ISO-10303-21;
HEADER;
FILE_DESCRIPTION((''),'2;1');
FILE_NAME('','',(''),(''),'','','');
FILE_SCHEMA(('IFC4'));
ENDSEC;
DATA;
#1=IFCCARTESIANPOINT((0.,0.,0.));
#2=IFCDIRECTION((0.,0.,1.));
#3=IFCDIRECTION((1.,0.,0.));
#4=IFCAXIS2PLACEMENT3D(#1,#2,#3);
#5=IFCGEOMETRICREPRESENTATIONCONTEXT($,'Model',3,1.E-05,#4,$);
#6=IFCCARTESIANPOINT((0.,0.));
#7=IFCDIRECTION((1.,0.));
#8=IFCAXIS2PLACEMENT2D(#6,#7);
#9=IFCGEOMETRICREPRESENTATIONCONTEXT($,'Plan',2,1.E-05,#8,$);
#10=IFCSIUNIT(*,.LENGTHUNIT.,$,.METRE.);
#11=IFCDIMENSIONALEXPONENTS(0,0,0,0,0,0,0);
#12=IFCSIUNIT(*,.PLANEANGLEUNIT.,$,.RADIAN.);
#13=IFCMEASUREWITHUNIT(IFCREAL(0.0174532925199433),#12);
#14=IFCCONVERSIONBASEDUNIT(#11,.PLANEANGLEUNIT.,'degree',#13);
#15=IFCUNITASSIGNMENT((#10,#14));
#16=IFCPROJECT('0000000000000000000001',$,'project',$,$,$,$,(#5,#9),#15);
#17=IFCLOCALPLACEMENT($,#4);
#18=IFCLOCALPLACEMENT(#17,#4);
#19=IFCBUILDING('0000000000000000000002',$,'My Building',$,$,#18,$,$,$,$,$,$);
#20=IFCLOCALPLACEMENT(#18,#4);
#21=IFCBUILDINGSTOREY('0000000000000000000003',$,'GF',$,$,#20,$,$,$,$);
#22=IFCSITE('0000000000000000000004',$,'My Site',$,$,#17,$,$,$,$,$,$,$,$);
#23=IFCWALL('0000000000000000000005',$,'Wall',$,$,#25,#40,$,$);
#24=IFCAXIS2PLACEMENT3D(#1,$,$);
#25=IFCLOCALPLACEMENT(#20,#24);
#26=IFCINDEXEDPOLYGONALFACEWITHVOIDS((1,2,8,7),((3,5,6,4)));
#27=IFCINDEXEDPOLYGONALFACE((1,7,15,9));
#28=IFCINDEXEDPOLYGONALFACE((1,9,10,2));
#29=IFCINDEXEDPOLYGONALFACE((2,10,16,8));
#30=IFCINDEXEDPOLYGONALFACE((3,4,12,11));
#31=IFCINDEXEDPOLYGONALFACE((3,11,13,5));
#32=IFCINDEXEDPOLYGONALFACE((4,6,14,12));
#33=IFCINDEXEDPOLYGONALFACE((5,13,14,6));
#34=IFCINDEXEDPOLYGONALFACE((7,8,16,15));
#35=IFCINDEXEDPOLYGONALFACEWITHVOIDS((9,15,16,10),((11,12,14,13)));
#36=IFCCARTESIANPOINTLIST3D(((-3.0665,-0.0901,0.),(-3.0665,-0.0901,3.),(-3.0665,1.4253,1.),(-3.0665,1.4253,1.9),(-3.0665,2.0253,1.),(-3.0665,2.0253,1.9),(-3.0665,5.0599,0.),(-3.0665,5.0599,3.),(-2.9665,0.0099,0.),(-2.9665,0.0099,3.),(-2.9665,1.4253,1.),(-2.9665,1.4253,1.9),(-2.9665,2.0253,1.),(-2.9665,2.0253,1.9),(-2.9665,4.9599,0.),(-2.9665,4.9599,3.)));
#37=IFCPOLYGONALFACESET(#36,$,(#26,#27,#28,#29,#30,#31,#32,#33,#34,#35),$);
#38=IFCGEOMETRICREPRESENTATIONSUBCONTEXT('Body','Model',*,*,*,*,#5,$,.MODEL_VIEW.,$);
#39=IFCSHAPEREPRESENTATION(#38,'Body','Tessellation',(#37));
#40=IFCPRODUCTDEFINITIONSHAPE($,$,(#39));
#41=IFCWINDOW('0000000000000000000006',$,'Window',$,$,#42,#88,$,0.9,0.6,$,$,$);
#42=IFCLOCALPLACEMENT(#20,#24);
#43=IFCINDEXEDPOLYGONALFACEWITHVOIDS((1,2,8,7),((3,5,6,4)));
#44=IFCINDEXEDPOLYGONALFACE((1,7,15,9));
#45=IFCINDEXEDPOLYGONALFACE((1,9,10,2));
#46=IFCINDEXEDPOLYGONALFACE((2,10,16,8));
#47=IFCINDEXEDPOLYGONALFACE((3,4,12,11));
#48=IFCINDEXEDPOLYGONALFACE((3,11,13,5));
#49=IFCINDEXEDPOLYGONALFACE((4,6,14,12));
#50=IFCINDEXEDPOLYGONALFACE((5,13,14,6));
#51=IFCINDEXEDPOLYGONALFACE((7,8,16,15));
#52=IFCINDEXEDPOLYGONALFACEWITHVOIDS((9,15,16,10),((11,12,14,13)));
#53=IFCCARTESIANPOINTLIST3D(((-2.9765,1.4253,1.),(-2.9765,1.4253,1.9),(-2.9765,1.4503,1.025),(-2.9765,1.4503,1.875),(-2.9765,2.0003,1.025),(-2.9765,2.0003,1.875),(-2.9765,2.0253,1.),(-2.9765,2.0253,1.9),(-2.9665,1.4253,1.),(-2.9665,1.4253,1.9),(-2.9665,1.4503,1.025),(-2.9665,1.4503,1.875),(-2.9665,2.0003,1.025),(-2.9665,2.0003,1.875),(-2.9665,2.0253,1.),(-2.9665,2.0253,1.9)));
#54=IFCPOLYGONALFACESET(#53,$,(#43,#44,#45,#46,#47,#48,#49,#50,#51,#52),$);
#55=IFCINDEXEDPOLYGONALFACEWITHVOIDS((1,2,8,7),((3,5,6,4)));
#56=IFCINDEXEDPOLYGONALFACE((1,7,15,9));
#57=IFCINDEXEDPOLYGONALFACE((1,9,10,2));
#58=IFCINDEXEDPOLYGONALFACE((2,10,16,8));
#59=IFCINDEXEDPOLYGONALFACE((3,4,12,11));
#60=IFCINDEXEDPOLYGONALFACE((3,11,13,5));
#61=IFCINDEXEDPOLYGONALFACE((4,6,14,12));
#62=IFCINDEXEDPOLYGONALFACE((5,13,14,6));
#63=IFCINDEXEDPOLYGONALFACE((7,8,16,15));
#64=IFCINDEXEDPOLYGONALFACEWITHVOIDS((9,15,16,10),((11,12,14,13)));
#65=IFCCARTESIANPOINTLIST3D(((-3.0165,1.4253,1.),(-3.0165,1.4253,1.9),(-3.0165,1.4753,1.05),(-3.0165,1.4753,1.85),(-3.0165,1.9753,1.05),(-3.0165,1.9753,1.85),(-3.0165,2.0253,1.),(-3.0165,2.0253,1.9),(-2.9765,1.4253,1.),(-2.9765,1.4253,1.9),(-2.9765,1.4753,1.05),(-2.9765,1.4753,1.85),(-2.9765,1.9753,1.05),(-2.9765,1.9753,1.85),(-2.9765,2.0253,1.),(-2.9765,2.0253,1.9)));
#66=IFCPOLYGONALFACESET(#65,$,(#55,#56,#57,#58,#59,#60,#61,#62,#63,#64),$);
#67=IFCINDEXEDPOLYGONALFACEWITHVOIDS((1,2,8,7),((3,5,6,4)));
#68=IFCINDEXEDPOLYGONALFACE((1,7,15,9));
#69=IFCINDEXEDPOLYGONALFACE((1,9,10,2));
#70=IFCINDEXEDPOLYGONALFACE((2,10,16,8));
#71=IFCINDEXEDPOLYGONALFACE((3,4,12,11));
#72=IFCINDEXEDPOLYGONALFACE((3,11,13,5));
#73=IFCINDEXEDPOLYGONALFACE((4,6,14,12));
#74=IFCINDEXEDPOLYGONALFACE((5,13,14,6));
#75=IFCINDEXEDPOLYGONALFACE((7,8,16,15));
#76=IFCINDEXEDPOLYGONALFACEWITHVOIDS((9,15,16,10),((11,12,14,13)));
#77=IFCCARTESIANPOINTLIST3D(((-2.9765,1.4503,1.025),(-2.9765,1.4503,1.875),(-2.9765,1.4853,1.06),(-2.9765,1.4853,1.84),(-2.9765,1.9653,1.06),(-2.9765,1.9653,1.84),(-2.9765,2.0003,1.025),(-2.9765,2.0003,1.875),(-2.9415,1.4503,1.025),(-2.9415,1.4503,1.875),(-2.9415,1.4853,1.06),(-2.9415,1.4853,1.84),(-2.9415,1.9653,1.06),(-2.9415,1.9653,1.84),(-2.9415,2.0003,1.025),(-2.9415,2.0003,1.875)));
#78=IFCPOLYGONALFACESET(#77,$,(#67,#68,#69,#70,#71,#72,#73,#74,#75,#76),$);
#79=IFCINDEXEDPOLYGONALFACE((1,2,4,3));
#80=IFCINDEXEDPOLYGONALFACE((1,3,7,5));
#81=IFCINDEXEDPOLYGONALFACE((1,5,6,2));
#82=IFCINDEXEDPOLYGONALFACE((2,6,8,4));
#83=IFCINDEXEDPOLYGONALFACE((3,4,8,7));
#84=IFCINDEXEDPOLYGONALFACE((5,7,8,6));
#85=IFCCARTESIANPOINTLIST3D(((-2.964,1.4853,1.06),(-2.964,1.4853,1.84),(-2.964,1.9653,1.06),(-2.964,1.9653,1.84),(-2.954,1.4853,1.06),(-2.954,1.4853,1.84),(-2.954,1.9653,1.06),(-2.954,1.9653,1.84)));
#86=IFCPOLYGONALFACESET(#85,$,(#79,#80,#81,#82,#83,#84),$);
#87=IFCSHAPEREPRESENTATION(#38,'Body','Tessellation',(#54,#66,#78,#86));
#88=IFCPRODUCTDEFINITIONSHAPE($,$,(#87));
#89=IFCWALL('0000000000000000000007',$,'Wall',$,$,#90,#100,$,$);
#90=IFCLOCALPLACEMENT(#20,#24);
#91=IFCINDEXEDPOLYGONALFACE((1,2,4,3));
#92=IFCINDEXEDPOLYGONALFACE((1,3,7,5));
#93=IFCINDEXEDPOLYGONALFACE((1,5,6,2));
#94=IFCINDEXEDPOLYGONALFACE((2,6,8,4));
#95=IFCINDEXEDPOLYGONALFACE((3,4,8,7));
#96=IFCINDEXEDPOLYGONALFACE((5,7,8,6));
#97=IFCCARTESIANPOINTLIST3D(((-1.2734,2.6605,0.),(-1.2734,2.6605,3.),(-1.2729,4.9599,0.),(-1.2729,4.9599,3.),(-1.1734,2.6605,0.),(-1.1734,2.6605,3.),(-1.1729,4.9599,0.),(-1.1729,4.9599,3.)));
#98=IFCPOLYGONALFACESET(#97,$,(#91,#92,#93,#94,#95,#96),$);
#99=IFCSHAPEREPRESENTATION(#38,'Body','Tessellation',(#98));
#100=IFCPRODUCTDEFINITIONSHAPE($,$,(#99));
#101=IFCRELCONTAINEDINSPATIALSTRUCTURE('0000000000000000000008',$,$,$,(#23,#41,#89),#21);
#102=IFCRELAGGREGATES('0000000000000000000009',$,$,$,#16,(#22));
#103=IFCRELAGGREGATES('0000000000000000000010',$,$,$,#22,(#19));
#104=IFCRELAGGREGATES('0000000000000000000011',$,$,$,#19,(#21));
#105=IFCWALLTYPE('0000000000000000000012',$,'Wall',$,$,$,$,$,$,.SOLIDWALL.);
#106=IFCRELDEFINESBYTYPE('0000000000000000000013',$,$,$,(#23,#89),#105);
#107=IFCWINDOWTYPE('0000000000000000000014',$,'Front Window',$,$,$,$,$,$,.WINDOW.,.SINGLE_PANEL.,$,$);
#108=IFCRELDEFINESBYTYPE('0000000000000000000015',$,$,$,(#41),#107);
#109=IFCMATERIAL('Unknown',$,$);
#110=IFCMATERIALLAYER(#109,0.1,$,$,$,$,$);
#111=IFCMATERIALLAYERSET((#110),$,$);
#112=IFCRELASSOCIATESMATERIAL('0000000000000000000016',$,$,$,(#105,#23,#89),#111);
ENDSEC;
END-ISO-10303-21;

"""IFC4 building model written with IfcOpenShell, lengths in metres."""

from ifc_helpers import new_model, entity, si_unit, converted_unit, frame, origin_with_axes, origin_2d_with_axis, place, context, subcontext, project, spatial, line, indexed_curve, outline, extrude, shape, source, transform, mapped, material, layer, layer_set, layer_usage, type_object, type_shapes, element, fill, save


model = new_model("IFC4")

# Units and contexts
model_context = context("Model", 3, precision=1e-05, world=origin_with_axes())
plan_context = context("Plan", 2, precision=1e-05, world=origin_2d_with_axis())
body_context_1 = subcontext(model_context, "Body", "Model", "MODEL_VIEW")
body_context_2 = subcontext(plan_context, "Body", "Plan", "PLAN_VIEW")
ifc_project = project(units=[si_unit("LENGTHUNIT", "METRE"), converted_unit("PLANEANGLEUNIT", "degree", entity("IfcReal", 0.0174532925199433), si_unit("PLANEANGLEUNIT", "RADIAN"), dimensions=[0, 0, 0, 0, 0, 0, 0])], contexts=[model_context, plan_context])

# Site, building, storey
site_placement = place(None, origin_with_axes())
site = spatial("IfcSite", under=ifc_project, at=site_placement, Name="My Site")
building_placement = place(site_placement, origin_with_axes())
building = spatial("IfcBuilding", under=site, at=building_placement, Name="My Building")
storey_placement = place(building_placement, origin_with_axes())
storey = spatial("IfcBuildingStorey", under=building, at=storey_placement, Name="GF")

# Shared definitions
ifc_material = material(Name="Unknown")

# Shared definitions
ifc_layer = layer(ifc_material, 0.1)
ifc_layer_set = layer_set([ifc_layer])
wall_type = type_object("IfcWallType", Name="Wall", PredefinedType="SOLIDWALL", material=ifc_layer_set)

# Wall, opening, window
ifc_layer_usage_1 = layer_usage(ifc_layer_set, "AXIS2", "POSITIVE", 0.0)
wall_1_placement = place(storey_placement, frame((-3.0665, 5.0599, 0.0), z_axis=(0.0, 0.0, 1.0), x_axis=(0.0, -1.0, 0.0)))
wall_1 = element("IfcWall", 1, at=wall_1_placement, inside=storey, type_object=wall_type, material=ifc_layer_usage_1, Name="Wall", context=body_context_1, shape_type="SweptSolid", body=[
    extrude(outline(indexed_curve([(0.0, 0.0), (0.1, 0.1), (5.05, 0.1), (5.15, 0.0)], segments=[line(1, 2, 3, 4, 1)])), origin_with_axes(), (0.0, 0.0, 1.0), 3.0),
])
shared_shape_1 = source(origin_with_axes(), body_context_1, "Body", "SweptSolid", [
    extrude(outline(indexed_curve([(0.0, 0.0), (0.6, 0.0), (0.6, 0.9), (0.0, 0.9)], segments=[line(1, 2, 3, 4, 1)])), frame((0.0, -0.6, 0.0), z_axis=(0.0, -1.0, 0.0), x_axis=(1.0, 0.0, 0.0)), (0.0, 0.0, -1.0), 1.2),
])
opening_1_placement = place(wall_1_placement, frame((3.0346, 0.0, 1.0), z_axis=(0.0, 0.0, 1.0), x_axis=(1.0, 0.0, 0.0)))
opening_1 = element("IfcOpeningElement", 2, at=opening_1_placement, cuts=wall_1, PredefinedType="OPENING", context=body_context_1, shape_type="MappedRepresentation", body=[
    mapped(shared_shape_1, transform((0.0, 0.0, 0.0), x_axis=(1.0, 0.0, 0.0), y_axis=(0.0, 1.0, 0.0), z_axis=(0.0, 0.0, 1.0), scale=1.0)),
])
window_type_1 = type_object("IfcWindowType", Name="Front Window", PartitioningType="SINGLE_PANEL", PredefinedType="WINDOW")
shared_shape_2 = source(origin_with_axes(), body_context_1, "Body", "SweptSolid", [
    extrude(outline(indexed_curve([(0.0, 0.0), (0.6, 0.0), (0.6, 0.9), (0.0, 0.9)], segments=[line(1, 2, 3, 4, 1)]), holes=[indexed_curve([(0.025, 0.025), (0.575, 0.025), (0.575, 0.875), (0.025, 0.875)], segments=[line(1, 2, 3, 4, 1)])]), frame((0.0, 0.09, 0.0), z_axis=(0.0, -1.0, 0.0), x_axis=(1.0, 0.0, 0.0)), (0.0, 0.0, -1.0), 0.01),
    extrude(outline(indexed_curve([(0.0, 0.0), (0.6, 0.0), (0.6, 0.9), (0.0, 0.9)], segments=[line(1, 2, 3, 4, 1)]), holes=[indexed_curve([(0.05, 0.05), (0.55, 0.05), (0.55, 0.85), (0.05, 0.85)], segments=[line(1, 2, 3, 4, 1)])]), frame((0.0, 0.05, 0.0), z_axis=(0.0, -1.0, 0.0), x_axis=(1.0, 0.0, 0.0)), (0.0, 0.0, -1.0), 0.04),
    extrude(outline(indexed_curve([(0.0, 0.0), (0.55, 0.0), (0.55, 0.85), (0.0, 0.85)], segments=[line(1, 2, 3, 4, 1)]), holes=[indexed_curve([(0.035, 0.035), (0.515, 0.035), (0.515, 0.815), (0.035, 0.815)], segments=[line(1, 2, 3, 4, 1)])]), frame((0.025, 0.09, 0.025), z_axis=(0.0, -1.0, 0.0), x_axis=(1.0, 0.0, 0.0)), (0.0, 0.0, -1.0), 0.035),
    extrude(outline(indexed_curve([(0.035, 0.035), (0.515, 0.035), (0.515, 0.815), (0.035, 0.815)], segments=[line(1, 2, 3, 4, 1)])), frame((0.025, 0.1025, 0.025), z_axis=(0.0, -1.0, 0.0), x_axis=(1.0, 0.0, 0.0)), (0.0, 0.0, -1.0), 0.01),
])
shared_shape_3 = source(origin_with_axes(), body_context_2, "Body", "Curve2D", [
    entity("IfcIndexedPolyCurve", entity("IfcCartesianPointList2D", [[0.05, 0.05], [0.55, 0.05]])),
    entity("IfcIndexedPolyCurve", entity("IfcCartesianPointList2D", [[0.0, 0.1], [0.025, 0.1], [0.025, 0.09], [0.05, 0.09], [0.05, 0.05], [0.0, 0.05]]), [entity("IfcLineIndex", [1, 2, 3, 4, 5, 6, 1])]),
    entity("IfcIndexedPolyCurve", entity("IfcCartesianPointList2D", [[0.6, 0.1], [0.575, 0.1], [0.575, 0.09], [0.55, 0.09], [0.55, 0.05], [0.6, 0.05]]), [entity("IfcLineIndex", [1, 2, 3, 4, 5, 6, 1])]),
    entity("IfcIndexedPolyCurve", entity("IfcCartesianPointList2D", [[0.025, 0.09], [0.06, 0.09], [0.06, 0.125], [0.025, 0.125]]), [entity("IfcLineIndex", [1, 2, 3, 4, 1])]),
    entity("IfcIndexedPolyCurve", entity("IfcCartesianPointList2D", [[0.575, 0.09], [0.54, 0.09], [0.54, 0.125], [0.575, 0.125]]), [entity("IfcLineIndex", [1, 2, 3, 4, 1])]),
    entity("IfcIndexedPolyCurve", entity("IfcCartesianPointList2D", [[0.06, 0.09], [0.54, 0.09]])),
    entity("IfcIndexedPolyCurve", entity("IfcCartesianPointList2D", [[0.06, 0.125], [0.54, 0.125]])),
    entity("IfcIndexedPolyCurve", entity("IfcCartesianPointList2D", [[0.06, 0.1075], [0.54, 0.1075]])),
])
type_shapes(window_type_1, [shared_shape_2, shared_shape_3])
window_1_placement = place(opening_1_placement, frame((0.0, 0.0, 0.0), z_axis=(0.0, 0.0, 1.0), x_axis=(1.0, 0.0, 0.0)))
window_1 = element("IfcWindow", 3, at=window_1_placement, inside=storey, type_object=window_type_1, Name="Window", OverallHeight=0.9, OverallWidth=0.6, shapes=[
    shape(body_context_1, "Body", "MappedRepresentation", [mapped(shared_shape_2, transform((0.0, 0.0, 0.0), x_axis=(1.0, 0.0, 0.0), y_axis=(0.0, 1.0, 0.0), z_axis=(0.0, 0.0, 1.0), scale=1.0))]),
    shape(body_context_2, "Body", "MappedRepresentation", [mapped(shared_shape_3, transform((0.0, 0.0, 0.0), x_axis=(1.0, 0.0, 0.0), y_axis=(0.0, 1.0, 0.0), z_axis=(0.0, 0.0, 1.0), scale=1.0))]),
])
fill(opening_1, window_1)

# Wall
ifc_layer_usage_2 = layer_usage(ifc_layer_set, "AXIS2", "POSITIVE", 0.0)
wall_2_placement = place(storey_placement, frame((-1.1734, 2.6605, 0.0), z_axis=(0.0, 0.0, 1.0), x_axis=(0.000197, 1.0, 0.0)))
element("IfcWall", 4, at=wall_2_placement, inside=storey, type_object=wall_type, material=ifc_layer_usage_2, Name="Wall", context=body_context_1, shape_type="SweptSolid", body=[
    extrude(outline(indexed_curve([(0.0, 0.0), (0.0, 0.1), (2.2994, 0.1), (2.2994, 0.0)], segments=[line(1, 2, 3, 4, 1)])), origin_with_axes(), (0.0, 0.0, 1.0), 3.0),
])

save(model, "model.ifc")
